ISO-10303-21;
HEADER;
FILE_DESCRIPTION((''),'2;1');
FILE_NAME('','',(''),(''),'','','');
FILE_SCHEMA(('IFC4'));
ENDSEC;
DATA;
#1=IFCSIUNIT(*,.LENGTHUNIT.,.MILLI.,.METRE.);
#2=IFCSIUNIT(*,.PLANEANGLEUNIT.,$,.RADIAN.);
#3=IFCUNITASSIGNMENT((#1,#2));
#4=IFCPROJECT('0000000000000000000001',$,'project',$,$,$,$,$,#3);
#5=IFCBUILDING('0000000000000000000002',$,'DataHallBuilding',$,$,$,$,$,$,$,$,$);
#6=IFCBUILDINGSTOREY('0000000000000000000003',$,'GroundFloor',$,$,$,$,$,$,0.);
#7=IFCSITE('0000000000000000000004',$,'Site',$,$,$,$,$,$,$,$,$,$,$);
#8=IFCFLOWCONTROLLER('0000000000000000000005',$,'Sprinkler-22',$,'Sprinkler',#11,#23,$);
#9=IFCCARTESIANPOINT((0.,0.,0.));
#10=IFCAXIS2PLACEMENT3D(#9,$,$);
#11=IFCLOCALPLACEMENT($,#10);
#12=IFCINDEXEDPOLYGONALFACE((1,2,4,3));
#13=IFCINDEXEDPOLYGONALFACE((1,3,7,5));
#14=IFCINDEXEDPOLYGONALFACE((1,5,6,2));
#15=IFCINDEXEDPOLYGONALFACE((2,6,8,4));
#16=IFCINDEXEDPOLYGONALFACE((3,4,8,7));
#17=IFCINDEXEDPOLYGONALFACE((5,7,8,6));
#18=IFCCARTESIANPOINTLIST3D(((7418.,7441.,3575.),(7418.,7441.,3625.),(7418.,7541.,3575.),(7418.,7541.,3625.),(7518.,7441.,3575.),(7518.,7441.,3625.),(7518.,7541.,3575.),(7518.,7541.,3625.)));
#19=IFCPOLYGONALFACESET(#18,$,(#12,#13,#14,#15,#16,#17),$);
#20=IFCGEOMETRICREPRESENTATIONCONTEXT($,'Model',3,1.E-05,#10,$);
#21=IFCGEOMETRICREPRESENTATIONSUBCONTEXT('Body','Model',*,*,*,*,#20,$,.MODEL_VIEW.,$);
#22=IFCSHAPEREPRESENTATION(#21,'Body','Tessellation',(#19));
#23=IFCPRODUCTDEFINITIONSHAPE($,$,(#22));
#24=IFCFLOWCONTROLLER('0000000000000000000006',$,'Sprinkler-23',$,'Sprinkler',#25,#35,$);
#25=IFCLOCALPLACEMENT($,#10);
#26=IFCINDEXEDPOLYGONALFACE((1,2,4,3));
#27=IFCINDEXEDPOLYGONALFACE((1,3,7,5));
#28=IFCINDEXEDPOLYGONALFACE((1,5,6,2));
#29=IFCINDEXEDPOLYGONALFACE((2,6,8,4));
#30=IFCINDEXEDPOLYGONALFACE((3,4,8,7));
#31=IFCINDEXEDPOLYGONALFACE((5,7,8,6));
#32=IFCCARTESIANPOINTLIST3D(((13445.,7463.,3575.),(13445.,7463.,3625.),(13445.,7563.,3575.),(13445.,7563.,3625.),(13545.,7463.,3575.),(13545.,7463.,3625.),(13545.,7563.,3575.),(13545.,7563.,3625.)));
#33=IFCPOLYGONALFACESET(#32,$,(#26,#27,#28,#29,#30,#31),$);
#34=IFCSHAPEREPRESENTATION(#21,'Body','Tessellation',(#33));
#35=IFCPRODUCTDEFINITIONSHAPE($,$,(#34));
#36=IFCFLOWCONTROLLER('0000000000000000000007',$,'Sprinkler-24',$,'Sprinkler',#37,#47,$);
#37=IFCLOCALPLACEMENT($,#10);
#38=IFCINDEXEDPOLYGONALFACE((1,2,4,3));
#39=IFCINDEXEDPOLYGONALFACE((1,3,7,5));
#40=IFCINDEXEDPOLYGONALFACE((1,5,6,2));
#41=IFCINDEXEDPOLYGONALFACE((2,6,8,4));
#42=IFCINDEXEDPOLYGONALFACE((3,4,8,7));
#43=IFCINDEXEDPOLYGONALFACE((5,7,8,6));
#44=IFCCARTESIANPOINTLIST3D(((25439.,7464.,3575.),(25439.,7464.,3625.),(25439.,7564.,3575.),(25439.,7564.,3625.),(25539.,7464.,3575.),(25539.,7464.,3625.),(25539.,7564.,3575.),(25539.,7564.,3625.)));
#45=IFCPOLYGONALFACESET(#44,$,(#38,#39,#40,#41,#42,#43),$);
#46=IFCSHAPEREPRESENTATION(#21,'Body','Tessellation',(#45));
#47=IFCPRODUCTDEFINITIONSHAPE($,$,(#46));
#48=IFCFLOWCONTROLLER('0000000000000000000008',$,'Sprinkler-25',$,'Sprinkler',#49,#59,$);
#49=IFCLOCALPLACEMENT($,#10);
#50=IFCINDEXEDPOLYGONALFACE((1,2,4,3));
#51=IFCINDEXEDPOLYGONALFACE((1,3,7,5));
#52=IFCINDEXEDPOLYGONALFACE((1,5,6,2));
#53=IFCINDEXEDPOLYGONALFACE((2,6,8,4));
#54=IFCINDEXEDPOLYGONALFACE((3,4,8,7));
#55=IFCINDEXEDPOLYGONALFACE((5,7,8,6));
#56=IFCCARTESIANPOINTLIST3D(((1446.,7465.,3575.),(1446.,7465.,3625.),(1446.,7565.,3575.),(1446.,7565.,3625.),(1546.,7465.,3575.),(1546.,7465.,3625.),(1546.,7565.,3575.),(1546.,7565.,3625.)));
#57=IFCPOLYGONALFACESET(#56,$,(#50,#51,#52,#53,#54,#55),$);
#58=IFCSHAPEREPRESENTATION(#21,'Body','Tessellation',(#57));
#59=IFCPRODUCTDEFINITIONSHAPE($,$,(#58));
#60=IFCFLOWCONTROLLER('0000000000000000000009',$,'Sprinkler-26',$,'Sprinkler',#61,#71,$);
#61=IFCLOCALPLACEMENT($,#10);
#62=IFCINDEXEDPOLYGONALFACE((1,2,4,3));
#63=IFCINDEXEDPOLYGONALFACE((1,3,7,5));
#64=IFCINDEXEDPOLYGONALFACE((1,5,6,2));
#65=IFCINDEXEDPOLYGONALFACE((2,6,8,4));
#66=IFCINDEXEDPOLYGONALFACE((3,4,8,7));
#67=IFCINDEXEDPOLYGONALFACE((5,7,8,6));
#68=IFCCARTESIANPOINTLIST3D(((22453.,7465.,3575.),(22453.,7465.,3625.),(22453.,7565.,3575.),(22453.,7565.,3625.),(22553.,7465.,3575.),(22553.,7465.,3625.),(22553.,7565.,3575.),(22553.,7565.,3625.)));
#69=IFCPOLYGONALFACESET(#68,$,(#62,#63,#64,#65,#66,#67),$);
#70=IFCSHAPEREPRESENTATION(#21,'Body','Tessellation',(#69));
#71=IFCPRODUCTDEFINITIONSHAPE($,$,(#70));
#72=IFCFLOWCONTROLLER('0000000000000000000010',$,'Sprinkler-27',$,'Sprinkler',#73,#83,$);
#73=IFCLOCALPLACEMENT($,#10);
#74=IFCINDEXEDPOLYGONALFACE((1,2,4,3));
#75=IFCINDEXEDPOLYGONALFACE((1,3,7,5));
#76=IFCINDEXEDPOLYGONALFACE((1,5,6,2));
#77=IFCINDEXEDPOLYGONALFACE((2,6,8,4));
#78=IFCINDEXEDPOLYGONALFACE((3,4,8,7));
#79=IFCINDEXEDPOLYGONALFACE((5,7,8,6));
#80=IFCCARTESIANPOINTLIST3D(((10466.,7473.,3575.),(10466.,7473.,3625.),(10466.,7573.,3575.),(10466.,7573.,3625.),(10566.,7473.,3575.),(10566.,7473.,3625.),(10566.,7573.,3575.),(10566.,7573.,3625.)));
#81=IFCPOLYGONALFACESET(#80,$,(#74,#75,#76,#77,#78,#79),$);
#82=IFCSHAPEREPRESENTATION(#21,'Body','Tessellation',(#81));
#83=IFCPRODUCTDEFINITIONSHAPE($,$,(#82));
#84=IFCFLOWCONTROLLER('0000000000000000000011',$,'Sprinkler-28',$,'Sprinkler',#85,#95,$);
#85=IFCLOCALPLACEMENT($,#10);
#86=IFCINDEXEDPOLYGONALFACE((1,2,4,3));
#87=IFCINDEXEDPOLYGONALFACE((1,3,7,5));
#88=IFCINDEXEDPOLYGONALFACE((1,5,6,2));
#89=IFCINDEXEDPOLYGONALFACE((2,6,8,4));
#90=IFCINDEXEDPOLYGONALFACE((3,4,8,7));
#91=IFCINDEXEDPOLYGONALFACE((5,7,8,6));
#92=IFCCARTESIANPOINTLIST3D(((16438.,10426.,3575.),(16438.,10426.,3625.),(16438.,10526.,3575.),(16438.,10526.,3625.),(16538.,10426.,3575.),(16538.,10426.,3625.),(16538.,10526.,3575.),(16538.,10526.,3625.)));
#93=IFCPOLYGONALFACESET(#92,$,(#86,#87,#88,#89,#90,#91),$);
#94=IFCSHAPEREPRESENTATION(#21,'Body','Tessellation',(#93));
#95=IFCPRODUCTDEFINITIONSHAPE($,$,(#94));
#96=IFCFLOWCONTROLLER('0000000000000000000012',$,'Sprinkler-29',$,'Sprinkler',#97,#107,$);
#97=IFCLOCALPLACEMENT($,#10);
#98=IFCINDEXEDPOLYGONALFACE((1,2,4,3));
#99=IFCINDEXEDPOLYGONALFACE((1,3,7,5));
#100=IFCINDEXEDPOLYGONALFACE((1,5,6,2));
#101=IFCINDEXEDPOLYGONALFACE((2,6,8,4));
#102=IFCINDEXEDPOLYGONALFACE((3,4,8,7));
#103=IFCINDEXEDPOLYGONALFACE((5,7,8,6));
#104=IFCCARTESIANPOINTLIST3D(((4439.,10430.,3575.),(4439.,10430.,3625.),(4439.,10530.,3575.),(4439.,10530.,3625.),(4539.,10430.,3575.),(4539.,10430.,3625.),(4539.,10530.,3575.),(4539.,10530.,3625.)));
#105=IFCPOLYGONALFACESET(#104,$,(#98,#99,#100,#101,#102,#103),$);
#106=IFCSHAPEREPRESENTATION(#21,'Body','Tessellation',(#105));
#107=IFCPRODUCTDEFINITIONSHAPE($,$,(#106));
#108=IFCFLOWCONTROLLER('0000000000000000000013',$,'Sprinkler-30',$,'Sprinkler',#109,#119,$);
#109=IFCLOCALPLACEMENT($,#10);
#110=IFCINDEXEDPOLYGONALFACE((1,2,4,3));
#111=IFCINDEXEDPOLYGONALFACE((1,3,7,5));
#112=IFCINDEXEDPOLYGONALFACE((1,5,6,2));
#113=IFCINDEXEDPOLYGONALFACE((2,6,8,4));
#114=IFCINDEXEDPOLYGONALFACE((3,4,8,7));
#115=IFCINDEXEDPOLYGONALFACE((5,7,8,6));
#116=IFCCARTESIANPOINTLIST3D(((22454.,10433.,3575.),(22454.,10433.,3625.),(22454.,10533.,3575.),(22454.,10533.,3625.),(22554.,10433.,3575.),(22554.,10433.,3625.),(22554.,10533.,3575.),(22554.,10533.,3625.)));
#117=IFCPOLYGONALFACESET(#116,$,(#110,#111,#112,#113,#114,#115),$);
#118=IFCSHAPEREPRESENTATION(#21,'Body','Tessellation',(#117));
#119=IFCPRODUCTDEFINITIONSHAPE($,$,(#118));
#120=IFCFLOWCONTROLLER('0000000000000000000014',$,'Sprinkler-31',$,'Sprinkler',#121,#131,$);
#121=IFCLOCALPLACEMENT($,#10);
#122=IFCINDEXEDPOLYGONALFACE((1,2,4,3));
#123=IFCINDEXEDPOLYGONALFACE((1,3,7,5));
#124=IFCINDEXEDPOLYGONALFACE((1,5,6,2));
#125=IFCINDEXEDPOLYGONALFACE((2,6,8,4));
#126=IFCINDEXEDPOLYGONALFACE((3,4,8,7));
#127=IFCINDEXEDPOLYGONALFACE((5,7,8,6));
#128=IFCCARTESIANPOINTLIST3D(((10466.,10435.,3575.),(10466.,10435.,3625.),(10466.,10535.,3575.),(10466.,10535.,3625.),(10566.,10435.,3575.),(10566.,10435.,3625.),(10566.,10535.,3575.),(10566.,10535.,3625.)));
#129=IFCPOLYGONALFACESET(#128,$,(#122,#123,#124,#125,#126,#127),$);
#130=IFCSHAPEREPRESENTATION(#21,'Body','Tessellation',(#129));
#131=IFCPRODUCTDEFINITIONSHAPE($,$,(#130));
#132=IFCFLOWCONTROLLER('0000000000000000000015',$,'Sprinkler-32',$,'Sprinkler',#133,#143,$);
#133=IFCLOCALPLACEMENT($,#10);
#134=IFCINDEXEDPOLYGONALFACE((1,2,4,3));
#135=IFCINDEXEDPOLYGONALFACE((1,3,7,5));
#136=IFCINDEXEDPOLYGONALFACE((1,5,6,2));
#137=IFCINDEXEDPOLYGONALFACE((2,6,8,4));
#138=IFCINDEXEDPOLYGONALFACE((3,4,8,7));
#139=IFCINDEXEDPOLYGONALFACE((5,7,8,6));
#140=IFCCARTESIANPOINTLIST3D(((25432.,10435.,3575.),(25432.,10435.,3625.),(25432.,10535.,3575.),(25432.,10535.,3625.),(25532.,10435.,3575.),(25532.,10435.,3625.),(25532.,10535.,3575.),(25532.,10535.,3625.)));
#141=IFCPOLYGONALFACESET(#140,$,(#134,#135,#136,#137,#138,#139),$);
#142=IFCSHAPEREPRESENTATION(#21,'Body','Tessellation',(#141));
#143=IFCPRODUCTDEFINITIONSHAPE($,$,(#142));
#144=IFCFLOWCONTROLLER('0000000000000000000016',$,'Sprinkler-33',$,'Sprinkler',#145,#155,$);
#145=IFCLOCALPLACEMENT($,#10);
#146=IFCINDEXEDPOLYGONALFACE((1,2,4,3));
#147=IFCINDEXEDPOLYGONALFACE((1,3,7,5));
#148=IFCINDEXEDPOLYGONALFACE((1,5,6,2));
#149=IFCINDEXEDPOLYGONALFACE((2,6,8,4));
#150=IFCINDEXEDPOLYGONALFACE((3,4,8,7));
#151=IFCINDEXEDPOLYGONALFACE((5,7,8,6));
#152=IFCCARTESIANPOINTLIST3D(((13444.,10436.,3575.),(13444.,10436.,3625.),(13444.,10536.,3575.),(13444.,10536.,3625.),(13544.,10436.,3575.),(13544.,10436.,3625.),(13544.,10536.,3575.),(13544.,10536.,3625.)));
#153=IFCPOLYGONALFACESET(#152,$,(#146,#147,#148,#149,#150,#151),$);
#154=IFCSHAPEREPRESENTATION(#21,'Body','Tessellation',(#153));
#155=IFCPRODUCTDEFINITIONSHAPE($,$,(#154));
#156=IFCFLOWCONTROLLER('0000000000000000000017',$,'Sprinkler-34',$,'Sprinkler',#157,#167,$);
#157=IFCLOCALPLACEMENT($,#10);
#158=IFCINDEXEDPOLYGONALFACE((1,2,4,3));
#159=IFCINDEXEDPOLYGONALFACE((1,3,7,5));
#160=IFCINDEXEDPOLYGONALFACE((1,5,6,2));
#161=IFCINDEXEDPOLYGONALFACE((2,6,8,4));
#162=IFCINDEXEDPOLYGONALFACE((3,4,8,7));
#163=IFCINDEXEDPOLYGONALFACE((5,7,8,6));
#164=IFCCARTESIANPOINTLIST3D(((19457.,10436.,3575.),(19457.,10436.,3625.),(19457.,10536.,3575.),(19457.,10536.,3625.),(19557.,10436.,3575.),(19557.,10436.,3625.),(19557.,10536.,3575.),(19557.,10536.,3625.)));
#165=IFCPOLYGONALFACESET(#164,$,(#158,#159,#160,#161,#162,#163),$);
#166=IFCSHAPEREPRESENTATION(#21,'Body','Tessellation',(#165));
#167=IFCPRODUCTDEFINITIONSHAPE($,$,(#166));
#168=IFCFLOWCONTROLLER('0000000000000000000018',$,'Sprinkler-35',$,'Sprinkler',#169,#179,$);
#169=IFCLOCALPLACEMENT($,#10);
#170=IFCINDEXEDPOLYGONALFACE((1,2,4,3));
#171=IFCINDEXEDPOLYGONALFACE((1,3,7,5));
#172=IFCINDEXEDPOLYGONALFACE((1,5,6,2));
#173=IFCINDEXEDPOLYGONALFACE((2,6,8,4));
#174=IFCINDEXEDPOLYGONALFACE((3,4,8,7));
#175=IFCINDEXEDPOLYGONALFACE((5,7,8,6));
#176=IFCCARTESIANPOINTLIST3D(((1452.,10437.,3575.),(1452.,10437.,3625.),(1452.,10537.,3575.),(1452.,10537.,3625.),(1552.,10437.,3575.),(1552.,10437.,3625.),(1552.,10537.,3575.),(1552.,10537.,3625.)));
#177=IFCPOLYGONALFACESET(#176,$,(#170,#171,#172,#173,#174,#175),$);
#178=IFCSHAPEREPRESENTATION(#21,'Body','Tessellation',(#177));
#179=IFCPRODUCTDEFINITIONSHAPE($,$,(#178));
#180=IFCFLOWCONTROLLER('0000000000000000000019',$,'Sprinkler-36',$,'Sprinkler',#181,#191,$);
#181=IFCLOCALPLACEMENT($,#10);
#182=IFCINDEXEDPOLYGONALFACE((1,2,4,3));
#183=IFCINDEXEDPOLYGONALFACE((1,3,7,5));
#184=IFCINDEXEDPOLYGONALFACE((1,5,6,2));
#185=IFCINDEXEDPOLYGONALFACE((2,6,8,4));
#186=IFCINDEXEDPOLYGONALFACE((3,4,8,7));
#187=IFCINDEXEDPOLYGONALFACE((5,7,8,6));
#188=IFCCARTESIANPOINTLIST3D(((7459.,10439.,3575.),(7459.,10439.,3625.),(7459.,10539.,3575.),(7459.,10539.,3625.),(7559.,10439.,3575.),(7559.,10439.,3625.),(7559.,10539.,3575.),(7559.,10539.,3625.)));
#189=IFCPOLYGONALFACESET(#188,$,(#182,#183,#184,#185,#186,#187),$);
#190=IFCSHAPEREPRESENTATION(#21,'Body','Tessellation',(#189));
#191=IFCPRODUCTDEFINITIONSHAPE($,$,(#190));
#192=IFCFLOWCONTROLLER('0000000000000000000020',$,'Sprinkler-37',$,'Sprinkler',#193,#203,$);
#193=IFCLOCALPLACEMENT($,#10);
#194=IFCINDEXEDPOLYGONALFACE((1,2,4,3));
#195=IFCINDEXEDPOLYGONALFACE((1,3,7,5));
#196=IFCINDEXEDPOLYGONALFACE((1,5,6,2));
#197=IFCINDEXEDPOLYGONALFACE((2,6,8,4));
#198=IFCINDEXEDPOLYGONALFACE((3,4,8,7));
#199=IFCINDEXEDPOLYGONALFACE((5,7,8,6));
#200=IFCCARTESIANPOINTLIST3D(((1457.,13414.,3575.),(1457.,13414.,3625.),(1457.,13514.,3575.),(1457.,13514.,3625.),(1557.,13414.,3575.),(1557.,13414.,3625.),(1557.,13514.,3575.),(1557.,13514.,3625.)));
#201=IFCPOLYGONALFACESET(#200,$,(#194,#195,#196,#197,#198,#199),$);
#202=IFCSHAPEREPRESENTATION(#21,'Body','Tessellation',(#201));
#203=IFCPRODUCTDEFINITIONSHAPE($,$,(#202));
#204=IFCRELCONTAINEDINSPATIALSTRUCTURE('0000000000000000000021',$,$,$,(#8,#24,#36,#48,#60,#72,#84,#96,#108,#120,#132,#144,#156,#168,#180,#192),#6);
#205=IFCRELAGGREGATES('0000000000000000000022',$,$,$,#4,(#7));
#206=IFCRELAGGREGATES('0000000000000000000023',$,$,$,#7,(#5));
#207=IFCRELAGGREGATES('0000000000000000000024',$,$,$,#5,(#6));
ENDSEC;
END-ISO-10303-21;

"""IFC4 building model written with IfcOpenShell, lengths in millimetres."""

from ifc_helpers import new_model, si_unit, frame, origin, place, context, subcontext, project, spatial, rectangle, extrude, element, save


model = new_model("IFC4")

# Units and contexts
model_context = context("Model", 3, precision=1e-05, world=origin())
body_context = subcontext(model_context, "Body", "Model", "MODEL_VIEW")
ifc_project = project(units=[si_unit("LENGTHUNIT", "METRE", prefix="MILLI"), si_unit("PLANEANGLEUNIT", "RADIAN")])

# Site, building, storey
site = spatial("IfcSite", under=ifc_project, Name="Site")
building = spatial("IfcBuilding", under=site, Name="DataHallBuilding")
storey = spatial("IfcBuildingStorey", under=building, Name="GroundFloor", Elevation=0.0)

# Flow controllers
flow_controller_1_placement = place(None, origin())
element("IfcFlowController", 1, at=flow_controller_1_placement, inside=storey, Name="Sprinkler-22", ObjectType="Sprinkler", context=body_context, shape_type="SweptSolid", body=[
    extrude(rectangle(XDim=100.0, YDim=100.0), frame((7468.0, 7491.0, 3575.0), z_axis=(0.0, 0.0, 1.0), x_axis=(1.0, 0.0, 0.0)), (0.0, 0.0, 1.0), 50.0),
])
flow_controller_2_placement = place(None, origin())
element("IfcFlowController", 2, at=flow_controller_2_placement, inside=storey, Name="Sprinkler-23", ObjectType="Sprinkler", context=body_context, shape_type="SweptSolid", body=[
    extrude(rectangle(XDim=100.0, YDim=100.0), frame((13495.0, 7513.0, 3575.0), z_axis=(0.0, 0.0, 1.0), x_axis=(1.0, 0.0, 0.0)), (0.0, 0.0, 1.0), 50.0),
])
flow_controller_3_placement = place(None, origin())
element("IfcFlowController", 3, at=flow_controller_3_placement, inside=storey, Name="Sprinkler-24", ObjectType="Sprinkler", context=body_context, shape_type="SweptSolid", body=[
    extrude(rectangle(XDim=100.0, YDim=100.0), frame((25489.0, 7514.0, 3575.0), z_axis=(0.0, 0.0, 1.0), x_axis=(1.0, 0.0, 0.0)), (0.0, 0.0, 1.0), 50.0),
])
flow_controller_4_placement = place(None, origin())
element("IfcFlowController", 4, at=flow_controller_4_placement, inside=storey, Name="Sprinkler-25", ObjectType="Sprinkler", context=body_context, shape_type="SweptSolid", body=[
    extrude(rectangle(XDim=100.0, YDim=100.0), frame((1496.0, 7515.0, 3575.0), z_axis=(0.0, 0.0, 1.0), x_axis=(1.0, 0.0, 0.0)), (0.0, 0.0, 1.0), 50.0),
])
flow_controller_5_placement = place(None, origin())
element("IfcFlowController", 5, at=flow_controller_5_placement, inside=storey, Name="Sprinkler-26", ObjectType="Sprinkler", context=body_context, shape_type="SweptSolid", body=[
    extrude(rectangle(XDim=100.0, YDim=100.0), frame((22503.0, 7515.0, 3575.0), z_axis=(0.0, 0.0, 1.0), x_axis=(1.0, 0.0, 0.0)), (0.0, 0.0, 1.0), 50.0),
])
flow_controller_6_placement = place(None, origin())
element("IfcFlowController", 6, at=flow_controller_6_placement, inside=storey, Name="Sprinkler-27", ObjectType="Sprinkler", context=body_context, shape_type="SweptSolid", body=[
    extrude(rectangle(XDim=100.0, YDim=100.0), frame((10516.0, 7523.0, 3575.0), z_axis=(0.0, 0.0, 1.0), x_axis=(1.0, 0.0, 0.0)), (0.0, 0.0, 1.0), 50.0),
])
flow_controller_7_placement = place(None, origin())
element("IfcFlowController", 7, at=flow_controller_7_placement, inside=storey, Name="Sprinkler-28", ObjectType="Sprinkler", context=body_context, shape_type="SweptSolid", body=[
    extrude(rectangle(XDim=100.0, YDim=100.0), frame((16488.0, 10476.0, 3575.0), z_axis=(0.0, 0.0, 1.0), x_axis=(1.0, 0.0, 0.0)), (0.0, 0.0, 1.0), 50.0),
])
flow_controller_8_placement = place(None, origin())
element("IfcFlowController", 8, at=flow_controller_8_placement, inside=storey, Name="Sprinkler-29", ObjectType="Sprinkler", context=body_context, shape_type="SweptSolid", body=[
    extrude(rectangle(XDim=100.0, YDim=100.0), frame((4489.0, 10480.0, 3575.0), z_axis=(0.0, 0.0, 1.0), x_axis=(1.0, 0.0, 0.0)), (0.0, 0.0, 1.0), 50.0),
])
flow_controller_9_placement = place(None, origin())
element("IfcFlowController", 9, at=flow_controller_9_placement, inside=storey, Name="Sprinkler-30", ObjectType="Sprinkler", context=body_context, shape_type="SweptSolid", body=[
    extrude(rectangle(XDim=100.0, YDim=100.0), frame((22504.0, 10483.0, 3575.0), z_axis=(0.0, 0.0, 1.0), x_axis=(1.0, 0.0, 0.0)), (0.0, 0.0, 1.0), 50.0),
])
flow_controller_10_placement = place(None, origin())
element("IfcFlowController", 10, at=flow_controller_10_placement, inside=storey, Name="Sprinkler-31", ObjectType="Sprinkler", context=body_context, shape_type="SweptSolid", body=[
    extrude(rectangle(XDim=100.0, YDim=100.0), frame((10516.0, 10485.0, 3575.0), z_axis=(0.0, 0.0, 1.0), x_axis=(1.0, 0.0, 0.0)), (0.0, 0.0, 1.0), 50.0),
])
flow_controller_11_placement = place(None, origin())
element("IfcFlowController", 11, at=flow_controller_11_placement, inside=storey, Name="Sprinkler-32", ObjectType="Sprinkler", context=body_context, shape_type="SweptSolid", body=[
    extrude(rectangle(XDim=100.0, YDim=100.0), frame((25482.0, 10485.0, 3575.0), z_axis=(0.0, 0.0, 1.0), x_axis=(1.0, 0.0, 0.0)), (0.0, 0.0, 1.0), 50.0),
])
flow_controller_12_placement = place(None, origin())
element("IfcFlowController", 12, at=flow_controller_12_placement, inside=storey, Name="Sprinkler-33", ObjectType="Sprinkler", context=body_context, shape_type="SweptSolid", body=[
    extrude(rectangle(XDim=100.0, YDim=100.0), frame((13494.0, 10486.0, 3575.0), z_axis=(0.0, 0.0, 1.0), x_axis=(1.0, 0.0, 0.0)), (0.0, 0.0, 1.0), 50.0),
])
flow_controller_13_placement = place(None, origin())
element("IfcFlowController", 13, at=flow_controller_13_placement, inside=storey, Name="Sprinkler-34", ObjectType="Sprinkler", context=body_context, shape_type="SweptSolid", body=[
    extrude(rectangle(XDim=100.0, YDim=100.0), frame((19507.0, 10486.0, 3575.0), z_axis=(0.0, 0.0, 1.0), x_axis=(1.0, 0.0, 0.0)), (0.0, 0.0, 1.0), 50.0),
])
flow_controller_14_placement = place(None, origin())
element("IfcFlowController", 14, at=flow_controller_14_placement, inside=storey, Name="Sprinkler-35", ObjectType="Sprinkler", context=body_context, shape_type="SweptSolid", body=[
    extrude(rectangle(XDim=100.0, YDim=100.0), frame((1502.0, 10487.0, 3575.0), z_axis=(0.0, 0.0, 1.0), x_axis=(1.0, 0.0, 0.0)), (0.0, 0.0, 1.0), 50.0),
])
flow_controller_15_placement = place(None, origin())
element("IfcFlowController", 15, at=flow_controller_15_placement, inside=storey, Name="Sprinkler-36", ObjectType="Sprinkler", context=body_context, shape_type="SweptSolid", body=[
    extrude(rectangle(XDim=100.0, YDim=100.0), frame((7509.0, 10489.0, 3575.0), z_axis=(0.0, 0.0, 1.0), x_axis=(1.0, 0.0, 0.0)), (0.0, 0.0, 1.0), 50.0),
])
flow_controller_16_placement = place(None, origin())
element("IfcFlowController", 16, at=flow_controller_16_placement, inside=storey, Name="Sprinkler-37", ObjectType="Sprinkler", context=body_context, shape_type="SweptSolid", body=[
    extrude(rectangle(XDim=100.0, YDim=100.0), frame((1507.0, 13464.0, 3575.0), z_axis=(0.0, 0.0, 1.0), x_axis=(1.0, 0.0, 0.0)), (0.0, 0.0, 1.0), 50.0),
])

save(model, "model.ifc")
